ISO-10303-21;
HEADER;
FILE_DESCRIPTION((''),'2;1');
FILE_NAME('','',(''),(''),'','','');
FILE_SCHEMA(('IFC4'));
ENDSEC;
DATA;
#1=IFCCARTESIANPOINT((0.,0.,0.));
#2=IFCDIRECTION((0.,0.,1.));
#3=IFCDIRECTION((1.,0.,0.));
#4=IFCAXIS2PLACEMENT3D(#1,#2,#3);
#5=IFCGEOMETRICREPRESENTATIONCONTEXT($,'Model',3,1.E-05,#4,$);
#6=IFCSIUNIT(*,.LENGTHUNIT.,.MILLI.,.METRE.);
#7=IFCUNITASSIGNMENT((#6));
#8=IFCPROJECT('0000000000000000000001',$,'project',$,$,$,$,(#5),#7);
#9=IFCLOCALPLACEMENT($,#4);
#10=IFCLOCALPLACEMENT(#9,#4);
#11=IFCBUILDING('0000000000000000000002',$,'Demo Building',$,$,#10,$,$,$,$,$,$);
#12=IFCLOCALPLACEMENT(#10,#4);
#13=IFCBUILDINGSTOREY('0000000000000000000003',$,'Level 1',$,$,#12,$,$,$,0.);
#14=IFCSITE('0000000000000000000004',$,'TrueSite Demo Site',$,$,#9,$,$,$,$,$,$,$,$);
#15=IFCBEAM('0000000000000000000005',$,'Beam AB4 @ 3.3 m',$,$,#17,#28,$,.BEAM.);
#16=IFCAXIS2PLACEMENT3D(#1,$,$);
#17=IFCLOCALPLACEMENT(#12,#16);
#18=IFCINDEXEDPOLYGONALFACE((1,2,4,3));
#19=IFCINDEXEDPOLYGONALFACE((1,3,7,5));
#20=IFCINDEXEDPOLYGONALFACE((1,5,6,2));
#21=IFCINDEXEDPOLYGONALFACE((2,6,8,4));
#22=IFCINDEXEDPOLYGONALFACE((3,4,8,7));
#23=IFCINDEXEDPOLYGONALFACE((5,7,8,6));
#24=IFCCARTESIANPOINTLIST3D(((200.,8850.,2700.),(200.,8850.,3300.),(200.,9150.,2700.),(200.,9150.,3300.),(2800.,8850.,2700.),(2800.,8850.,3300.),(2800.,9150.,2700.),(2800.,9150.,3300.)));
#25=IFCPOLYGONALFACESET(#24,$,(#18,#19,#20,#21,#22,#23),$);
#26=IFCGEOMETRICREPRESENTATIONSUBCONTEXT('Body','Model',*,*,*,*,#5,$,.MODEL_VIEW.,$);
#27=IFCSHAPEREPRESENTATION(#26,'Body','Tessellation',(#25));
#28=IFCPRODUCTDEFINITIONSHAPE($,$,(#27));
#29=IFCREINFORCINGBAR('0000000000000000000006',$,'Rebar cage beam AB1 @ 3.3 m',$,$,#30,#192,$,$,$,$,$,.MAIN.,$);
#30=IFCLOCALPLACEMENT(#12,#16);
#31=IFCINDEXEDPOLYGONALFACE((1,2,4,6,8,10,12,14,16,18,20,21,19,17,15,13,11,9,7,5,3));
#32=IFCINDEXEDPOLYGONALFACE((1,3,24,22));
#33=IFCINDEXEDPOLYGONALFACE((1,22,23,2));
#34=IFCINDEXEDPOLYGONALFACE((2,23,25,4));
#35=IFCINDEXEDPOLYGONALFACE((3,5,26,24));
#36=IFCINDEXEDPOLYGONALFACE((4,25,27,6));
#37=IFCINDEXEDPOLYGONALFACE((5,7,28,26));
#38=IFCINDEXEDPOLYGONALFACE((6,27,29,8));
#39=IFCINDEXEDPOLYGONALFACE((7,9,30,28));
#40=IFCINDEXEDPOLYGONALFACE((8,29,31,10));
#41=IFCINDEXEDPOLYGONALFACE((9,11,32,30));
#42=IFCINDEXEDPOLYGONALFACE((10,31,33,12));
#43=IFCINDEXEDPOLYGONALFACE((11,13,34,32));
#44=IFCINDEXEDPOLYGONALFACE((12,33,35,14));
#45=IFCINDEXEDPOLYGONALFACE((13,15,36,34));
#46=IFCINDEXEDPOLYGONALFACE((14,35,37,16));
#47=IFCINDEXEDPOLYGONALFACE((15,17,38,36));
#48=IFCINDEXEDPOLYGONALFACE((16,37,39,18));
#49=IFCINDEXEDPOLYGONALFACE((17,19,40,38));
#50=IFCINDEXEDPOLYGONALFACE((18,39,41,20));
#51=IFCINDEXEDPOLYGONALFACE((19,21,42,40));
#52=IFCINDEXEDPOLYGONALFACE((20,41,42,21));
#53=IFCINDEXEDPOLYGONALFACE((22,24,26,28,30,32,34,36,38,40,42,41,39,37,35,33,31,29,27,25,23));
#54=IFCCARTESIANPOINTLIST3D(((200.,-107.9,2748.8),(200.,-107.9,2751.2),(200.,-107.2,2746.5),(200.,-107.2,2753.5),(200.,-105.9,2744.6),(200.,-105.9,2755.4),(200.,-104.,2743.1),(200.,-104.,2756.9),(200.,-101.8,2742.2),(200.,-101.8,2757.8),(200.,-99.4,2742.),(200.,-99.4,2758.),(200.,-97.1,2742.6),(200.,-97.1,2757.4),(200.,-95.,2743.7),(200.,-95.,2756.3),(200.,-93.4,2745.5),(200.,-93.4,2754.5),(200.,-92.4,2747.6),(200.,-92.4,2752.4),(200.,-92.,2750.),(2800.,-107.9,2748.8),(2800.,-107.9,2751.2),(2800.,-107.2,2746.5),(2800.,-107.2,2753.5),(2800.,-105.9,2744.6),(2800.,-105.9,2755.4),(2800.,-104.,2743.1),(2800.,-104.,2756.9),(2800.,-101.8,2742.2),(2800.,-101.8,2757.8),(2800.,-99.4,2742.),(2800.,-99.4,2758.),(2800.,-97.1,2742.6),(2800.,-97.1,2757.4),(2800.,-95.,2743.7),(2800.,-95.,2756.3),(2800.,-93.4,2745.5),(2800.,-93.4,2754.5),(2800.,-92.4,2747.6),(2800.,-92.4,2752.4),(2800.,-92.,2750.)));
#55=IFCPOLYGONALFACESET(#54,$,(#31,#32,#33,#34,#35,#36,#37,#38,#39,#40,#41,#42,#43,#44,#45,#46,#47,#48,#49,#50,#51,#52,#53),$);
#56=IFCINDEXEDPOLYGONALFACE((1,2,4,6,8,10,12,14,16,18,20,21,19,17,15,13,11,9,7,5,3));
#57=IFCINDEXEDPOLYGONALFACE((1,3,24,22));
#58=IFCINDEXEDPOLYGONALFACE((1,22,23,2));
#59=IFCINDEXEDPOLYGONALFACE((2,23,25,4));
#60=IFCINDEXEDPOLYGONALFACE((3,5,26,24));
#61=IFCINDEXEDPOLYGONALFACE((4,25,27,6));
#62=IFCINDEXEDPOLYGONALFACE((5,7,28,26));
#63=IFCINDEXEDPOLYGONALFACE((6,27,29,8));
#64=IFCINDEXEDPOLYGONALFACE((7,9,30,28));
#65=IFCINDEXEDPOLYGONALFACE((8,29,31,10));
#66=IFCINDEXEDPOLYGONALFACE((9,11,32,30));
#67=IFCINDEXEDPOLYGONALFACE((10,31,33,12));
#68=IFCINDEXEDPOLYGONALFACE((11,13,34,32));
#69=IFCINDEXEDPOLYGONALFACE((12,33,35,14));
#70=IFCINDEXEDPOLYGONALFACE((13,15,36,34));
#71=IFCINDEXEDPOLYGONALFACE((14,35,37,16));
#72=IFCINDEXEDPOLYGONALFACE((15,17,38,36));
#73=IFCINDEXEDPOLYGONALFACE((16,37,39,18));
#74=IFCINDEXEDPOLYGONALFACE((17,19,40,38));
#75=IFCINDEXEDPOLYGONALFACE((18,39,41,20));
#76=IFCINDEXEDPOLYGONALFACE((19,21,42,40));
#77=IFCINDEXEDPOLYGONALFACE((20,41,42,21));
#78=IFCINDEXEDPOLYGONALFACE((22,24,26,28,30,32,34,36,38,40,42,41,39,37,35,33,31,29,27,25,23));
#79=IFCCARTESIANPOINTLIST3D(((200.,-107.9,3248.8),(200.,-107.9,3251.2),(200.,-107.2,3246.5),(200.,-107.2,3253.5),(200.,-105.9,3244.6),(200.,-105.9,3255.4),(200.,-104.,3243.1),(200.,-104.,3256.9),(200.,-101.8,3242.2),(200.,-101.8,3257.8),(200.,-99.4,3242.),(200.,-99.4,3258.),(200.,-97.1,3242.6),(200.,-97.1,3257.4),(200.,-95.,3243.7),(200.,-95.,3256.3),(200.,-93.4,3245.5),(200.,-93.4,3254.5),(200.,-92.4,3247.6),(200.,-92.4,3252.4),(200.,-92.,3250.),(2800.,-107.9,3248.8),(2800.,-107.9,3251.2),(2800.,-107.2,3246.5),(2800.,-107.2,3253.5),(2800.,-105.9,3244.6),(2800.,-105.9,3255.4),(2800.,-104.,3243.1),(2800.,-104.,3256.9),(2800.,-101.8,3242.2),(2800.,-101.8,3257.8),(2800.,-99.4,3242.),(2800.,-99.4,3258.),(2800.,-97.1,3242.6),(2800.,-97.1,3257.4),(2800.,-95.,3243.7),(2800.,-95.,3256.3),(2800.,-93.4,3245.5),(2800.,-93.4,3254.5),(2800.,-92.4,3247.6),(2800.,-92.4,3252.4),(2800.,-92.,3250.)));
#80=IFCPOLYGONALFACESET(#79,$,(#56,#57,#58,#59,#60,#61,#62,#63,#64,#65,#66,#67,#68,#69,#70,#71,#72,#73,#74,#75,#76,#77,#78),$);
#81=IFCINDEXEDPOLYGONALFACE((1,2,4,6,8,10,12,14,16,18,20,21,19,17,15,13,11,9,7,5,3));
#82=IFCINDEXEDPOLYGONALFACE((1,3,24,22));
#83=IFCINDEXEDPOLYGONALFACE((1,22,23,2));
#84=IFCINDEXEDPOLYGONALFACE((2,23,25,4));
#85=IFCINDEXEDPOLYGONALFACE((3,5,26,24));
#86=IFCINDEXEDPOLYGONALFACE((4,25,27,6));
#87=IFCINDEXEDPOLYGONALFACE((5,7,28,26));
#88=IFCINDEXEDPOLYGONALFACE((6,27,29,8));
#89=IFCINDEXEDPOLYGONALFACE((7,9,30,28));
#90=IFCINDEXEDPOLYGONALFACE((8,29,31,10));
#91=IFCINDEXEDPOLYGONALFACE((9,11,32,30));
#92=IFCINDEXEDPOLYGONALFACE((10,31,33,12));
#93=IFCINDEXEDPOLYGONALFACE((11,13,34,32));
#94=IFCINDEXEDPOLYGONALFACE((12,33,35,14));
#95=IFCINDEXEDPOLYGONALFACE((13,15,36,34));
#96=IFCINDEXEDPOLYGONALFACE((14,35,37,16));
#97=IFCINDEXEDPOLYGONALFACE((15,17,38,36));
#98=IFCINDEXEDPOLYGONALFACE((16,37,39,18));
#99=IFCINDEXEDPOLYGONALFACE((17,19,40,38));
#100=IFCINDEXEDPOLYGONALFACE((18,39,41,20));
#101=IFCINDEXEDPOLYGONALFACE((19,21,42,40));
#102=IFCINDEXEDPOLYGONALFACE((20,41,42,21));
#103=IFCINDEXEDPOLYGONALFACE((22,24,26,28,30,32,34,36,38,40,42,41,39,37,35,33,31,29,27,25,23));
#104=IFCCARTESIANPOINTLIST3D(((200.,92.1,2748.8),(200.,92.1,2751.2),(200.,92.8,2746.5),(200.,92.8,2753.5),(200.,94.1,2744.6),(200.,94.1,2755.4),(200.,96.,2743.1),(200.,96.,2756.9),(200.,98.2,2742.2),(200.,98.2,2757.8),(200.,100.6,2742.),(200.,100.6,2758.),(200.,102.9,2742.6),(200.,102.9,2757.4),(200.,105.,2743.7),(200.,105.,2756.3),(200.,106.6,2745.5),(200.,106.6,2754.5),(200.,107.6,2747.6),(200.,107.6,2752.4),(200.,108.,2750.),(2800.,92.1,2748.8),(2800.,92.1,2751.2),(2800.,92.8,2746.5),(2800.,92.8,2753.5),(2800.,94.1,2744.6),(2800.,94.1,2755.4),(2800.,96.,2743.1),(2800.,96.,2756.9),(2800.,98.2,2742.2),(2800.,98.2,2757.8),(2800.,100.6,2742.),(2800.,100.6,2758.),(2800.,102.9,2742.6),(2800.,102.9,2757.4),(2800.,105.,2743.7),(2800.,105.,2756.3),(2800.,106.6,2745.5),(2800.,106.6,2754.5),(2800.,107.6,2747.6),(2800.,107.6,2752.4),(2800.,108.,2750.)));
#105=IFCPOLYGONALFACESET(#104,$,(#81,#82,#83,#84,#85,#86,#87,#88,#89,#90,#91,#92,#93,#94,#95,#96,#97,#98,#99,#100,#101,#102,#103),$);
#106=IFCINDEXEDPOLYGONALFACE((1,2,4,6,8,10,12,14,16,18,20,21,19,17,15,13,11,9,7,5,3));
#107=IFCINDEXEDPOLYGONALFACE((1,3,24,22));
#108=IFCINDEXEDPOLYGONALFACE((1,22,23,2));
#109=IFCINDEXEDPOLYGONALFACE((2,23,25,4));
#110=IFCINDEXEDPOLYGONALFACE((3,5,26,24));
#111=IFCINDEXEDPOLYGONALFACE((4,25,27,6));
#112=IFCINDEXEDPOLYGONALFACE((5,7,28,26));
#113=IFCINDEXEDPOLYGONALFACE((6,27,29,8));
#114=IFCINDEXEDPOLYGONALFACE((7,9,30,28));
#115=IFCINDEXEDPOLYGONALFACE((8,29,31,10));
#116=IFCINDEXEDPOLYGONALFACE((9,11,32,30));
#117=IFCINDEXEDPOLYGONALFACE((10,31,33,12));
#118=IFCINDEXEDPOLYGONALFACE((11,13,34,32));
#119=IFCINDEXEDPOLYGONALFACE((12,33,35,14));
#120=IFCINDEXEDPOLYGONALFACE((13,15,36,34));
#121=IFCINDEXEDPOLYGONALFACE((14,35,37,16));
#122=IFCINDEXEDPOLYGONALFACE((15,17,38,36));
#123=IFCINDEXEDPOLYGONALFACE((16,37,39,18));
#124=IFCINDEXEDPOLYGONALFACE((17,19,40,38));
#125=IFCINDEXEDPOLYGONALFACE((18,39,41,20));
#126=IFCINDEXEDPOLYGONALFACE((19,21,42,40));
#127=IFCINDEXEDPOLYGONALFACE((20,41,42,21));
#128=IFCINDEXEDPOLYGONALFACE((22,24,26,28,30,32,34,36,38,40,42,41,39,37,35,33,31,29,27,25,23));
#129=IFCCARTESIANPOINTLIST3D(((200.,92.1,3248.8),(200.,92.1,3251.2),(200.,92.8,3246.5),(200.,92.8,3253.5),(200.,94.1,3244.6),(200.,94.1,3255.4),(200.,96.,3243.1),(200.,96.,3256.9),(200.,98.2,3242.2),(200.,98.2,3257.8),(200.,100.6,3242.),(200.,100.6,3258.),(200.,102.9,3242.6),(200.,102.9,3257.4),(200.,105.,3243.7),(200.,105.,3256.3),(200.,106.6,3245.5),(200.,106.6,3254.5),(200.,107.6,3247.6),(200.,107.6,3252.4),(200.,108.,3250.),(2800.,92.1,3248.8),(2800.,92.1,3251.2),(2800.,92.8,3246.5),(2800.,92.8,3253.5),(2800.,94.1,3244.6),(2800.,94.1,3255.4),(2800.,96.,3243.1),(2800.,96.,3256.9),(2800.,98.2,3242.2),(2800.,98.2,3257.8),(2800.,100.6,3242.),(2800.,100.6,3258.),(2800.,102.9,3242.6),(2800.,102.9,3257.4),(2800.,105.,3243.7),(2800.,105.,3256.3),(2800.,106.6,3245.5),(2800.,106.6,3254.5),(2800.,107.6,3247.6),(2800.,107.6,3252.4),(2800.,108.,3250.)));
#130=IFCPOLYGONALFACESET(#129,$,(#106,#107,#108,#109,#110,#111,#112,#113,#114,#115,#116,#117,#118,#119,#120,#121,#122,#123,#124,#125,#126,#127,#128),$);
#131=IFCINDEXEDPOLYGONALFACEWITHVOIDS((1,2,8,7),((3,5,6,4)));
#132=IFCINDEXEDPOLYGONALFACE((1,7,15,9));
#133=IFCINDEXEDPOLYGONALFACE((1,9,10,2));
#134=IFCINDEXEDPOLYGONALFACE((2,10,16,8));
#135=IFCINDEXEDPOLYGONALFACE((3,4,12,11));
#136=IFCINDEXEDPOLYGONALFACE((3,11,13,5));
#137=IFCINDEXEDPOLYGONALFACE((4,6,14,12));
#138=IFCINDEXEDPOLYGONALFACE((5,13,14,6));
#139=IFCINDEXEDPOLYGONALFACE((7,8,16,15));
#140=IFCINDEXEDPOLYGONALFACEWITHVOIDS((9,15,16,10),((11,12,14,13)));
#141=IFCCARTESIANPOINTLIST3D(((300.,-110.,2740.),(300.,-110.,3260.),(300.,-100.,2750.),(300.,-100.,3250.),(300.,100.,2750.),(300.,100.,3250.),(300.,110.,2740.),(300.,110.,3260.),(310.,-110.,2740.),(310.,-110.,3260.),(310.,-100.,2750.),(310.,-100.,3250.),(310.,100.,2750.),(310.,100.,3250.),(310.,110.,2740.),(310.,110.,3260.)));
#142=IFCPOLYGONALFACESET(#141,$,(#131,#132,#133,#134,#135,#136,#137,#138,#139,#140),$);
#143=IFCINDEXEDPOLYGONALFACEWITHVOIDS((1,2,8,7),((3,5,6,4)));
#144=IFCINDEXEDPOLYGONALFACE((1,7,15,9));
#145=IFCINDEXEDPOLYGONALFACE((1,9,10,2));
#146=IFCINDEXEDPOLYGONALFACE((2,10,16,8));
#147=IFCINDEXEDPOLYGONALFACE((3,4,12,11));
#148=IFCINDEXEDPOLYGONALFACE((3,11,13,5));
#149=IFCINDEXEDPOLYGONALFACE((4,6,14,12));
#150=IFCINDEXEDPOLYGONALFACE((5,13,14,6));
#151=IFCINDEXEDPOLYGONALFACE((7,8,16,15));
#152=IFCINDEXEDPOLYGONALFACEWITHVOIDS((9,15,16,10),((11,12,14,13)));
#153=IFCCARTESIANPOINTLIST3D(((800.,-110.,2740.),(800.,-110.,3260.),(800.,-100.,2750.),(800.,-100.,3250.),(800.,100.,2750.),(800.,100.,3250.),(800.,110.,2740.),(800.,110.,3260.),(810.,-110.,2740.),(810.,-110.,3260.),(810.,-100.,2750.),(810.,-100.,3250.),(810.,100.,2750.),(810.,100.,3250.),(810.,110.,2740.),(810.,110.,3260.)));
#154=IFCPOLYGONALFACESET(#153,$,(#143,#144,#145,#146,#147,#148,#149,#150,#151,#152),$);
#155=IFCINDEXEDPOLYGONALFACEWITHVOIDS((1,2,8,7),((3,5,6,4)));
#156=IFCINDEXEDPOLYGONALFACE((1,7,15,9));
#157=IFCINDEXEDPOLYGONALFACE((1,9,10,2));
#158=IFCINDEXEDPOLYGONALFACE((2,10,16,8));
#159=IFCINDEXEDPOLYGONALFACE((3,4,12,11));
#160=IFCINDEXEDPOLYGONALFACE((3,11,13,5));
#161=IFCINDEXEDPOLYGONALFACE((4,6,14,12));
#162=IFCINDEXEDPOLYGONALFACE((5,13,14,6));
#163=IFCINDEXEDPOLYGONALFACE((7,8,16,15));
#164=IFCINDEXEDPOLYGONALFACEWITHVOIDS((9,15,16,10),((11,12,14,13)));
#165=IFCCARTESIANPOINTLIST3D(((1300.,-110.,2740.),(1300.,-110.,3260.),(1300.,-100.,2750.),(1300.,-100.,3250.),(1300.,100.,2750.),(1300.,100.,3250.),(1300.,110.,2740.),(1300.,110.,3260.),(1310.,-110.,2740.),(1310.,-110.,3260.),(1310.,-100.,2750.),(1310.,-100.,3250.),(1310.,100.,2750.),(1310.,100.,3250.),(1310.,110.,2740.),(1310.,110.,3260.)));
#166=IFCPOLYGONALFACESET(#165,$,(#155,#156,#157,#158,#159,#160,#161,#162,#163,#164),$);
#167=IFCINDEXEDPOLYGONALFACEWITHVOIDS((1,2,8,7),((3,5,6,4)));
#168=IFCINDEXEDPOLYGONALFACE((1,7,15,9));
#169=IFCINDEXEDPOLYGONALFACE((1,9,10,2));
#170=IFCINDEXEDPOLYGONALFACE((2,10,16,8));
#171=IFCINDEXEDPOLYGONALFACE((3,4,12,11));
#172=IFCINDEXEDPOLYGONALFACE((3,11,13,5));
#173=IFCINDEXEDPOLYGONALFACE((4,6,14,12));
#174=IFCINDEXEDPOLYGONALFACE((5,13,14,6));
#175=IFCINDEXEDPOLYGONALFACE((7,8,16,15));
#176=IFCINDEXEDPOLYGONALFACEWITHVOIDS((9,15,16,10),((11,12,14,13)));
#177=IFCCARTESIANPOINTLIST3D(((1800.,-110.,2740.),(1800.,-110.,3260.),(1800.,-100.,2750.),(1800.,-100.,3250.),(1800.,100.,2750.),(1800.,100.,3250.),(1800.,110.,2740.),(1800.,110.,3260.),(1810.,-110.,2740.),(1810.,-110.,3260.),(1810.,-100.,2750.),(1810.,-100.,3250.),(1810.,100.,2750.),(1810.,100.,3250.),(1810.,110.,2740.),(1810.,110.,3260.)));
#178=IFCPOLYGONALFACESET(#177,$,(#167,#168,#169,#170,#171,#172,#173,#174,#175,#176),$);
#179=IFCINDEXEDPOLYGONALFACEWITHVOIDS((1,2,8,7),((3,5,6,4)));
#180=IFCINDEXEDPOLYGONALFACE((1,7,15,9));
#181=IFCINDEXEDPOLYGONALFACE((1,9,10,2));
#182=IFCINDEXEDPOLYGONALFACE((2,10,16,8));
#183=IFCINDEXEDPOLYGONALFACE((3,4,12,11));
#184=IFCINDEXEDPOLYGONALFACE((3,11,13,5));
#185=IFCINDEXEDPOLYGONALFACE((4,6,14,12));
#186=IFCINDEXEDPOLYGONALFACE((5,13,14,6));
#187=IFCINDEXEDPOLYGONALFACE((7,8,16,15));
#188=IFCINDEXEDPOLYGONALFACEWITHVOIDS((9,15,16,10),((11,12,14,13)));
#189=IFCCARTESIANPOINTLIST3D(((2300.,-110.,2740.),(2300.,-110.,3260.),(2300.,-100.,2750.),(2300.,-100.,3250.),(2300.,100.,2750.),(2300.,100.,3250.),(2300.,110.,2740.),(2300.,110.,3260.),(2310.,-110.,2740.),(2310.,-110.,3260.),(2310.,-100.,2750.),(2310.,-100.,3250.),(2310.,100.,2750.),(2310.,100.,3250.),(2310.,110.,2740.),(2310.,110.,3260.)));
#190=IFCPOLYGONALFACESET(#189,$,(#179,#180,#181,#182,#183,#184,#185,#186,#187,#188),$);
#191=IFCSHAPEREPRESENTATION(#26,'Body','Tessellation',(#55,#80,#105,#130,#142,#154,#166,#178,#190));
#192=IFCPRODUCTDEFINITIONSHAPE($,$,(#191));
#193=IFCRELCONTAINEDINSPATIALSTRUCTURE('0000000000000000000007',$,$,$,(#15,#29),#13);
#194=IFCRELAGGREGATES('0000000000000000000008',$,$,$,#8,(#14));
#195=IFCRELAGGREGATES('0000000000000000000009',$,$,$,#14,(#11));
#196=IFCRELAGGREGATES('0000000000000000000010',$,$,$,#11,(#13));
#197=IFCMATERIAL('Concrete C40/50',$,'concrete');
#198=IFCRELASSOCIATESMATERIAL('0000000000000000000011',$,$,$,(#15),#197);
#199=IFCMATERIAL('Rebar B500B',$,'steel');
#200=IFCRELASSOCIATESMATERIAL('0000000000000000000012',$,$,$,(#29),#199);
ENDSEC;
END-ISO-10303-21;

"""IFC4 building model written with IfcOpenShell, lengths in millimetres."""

from ifc_helpers import new_model, si_unit, frame, origin_with_axes, place, context, subcontext, project, spatial, rectangle, hollow_rectangle, circle, extrude, material, element, save


model = new_model("IFC4")

# Units and contexts
model_context = context("Model", 3, precision=1e-05, world=origin_with_axes())
body_context = subcontext(model_context, "Body", "Model", "MODEL_VIEW")
ifc_project = project(units=[si_unit("LENGTHUNIT", "METRE", prefix="MILLI")], contexts=[model_context])

# Site, building, storey
site_placement = place(None, origin_with_axes())
site = spatial("IfcSite", under=ifc_project, at=site_placement, Name="TrueSite Demo Site")
building_placement = place(site_placement, origin_with_axes())
building = spatial("IfcBuilding", under=site, at=building_placement, Name="Demo Building")
storey_placement = place(building_placement, origin_with_axes())
storey = spatial("IfcBuildingStorey", under=building, at=storey_placement, Name="Level 1", Elevation=0.0)

# Shared definitions
ifc_material_1 = material(Name="Concrete C40/50", Category="concrete")

# Beam
for number, where, z_axis, x_axis, name in (
    (1, (200.0, 9000.0, 3000.0), (1.0, 0.0, 0.0), (0.0, 1.0, 0.0), "Beam AB4 @ 3.3 m"),
):
    element("IfcBeam", number, at=place(storey_placement, frame(where, z_axis=z_axis, x_axis=x_axis)), inside=storey, material=ifc_material_1, Name=name, PredefinedType="BEAM", context=body_context, shape_type="SweptSolid", body=[
        extrude(rectangle(XDim=300.0, YDim=600.0), origin_with_axes(), (0.0, 0.0, 1.0), 2600.0),
    ])

# Reinforcing bar
ifc_material_2 = material(Name="Rebar B500B", Category="steel")
for number, where, z_axis, x_axis, name in (
    (2, (200.0, 0.0, 3000.0), (1.0, 0.0, 0.0), (0.0, 1.0, 0.0), "Rebar cage beam AB1 @ 3.3 m"),
):
    element("IfcReinforcingBar", number, at=place(storey_placement, frame(where, z_axis=z_axis, x_axis=x_axis)), inside=storey, material=ifc_material_2, Name=name, PredefinedType="MAIN", context=body_context, shape_type="SweptSolid", body=[
        extrude(circle(Radius=8.0), frame((-100.0, -250.0, 0.0)), (0.0, 0.0, 1.0), 2600.0),
        extrude(circle(Radius=8.0), frame((-100.0, 250.0, 0.0)), (0.0, 0.0, 1.0), 2600.0),
        extrude(circle(Radius=8.0), frame((100.0, -250.0, 0.0)), (0.0, 0.0, 1.0), 2600.0),
        extrude(circle(Radius=8.0), frame((100.0, 250.0, 0.0)), (0.0, 0.0, 1.0), 2600.0),
        extrude(hollow_rectangle(XDim=220.0, YDim=520.0, WallThickness=10.0), frame((0.0, 0.0, 100.0)), (0.0, 0.0, 1.0), 10.0),
        extrude(hollow_rectangle(XDim=220.0, YDim=520.0, WallThickness=10.0), frame((0.0, 0.0, 600.0)), (0.0, 0.0, 1.0), 10.0),
        extrude(hollow_rectangle(XDim=220.0, YDim=520.0, WallThickness=10.0), frame((0.0, 0.0, 1100.0)), (0.0, 0.0, 1.0), 10.0),
        extrude(hollow_rectangle(XDim=220.0, YDim=520.0, WallThickness=10.0), frame((0.0, 0.0, 1600.0)), (0.0, 0.0, 1.0), 10.0),
        extrude(hollow_rectangle(XDim=220.0, YDim=520.0, WallThickness=10.0), frame((0.0, 0.0, 2100.0)), (0.0, 0.0, 1.0), 10.0),
    ])

save(model, "model.ifc")
